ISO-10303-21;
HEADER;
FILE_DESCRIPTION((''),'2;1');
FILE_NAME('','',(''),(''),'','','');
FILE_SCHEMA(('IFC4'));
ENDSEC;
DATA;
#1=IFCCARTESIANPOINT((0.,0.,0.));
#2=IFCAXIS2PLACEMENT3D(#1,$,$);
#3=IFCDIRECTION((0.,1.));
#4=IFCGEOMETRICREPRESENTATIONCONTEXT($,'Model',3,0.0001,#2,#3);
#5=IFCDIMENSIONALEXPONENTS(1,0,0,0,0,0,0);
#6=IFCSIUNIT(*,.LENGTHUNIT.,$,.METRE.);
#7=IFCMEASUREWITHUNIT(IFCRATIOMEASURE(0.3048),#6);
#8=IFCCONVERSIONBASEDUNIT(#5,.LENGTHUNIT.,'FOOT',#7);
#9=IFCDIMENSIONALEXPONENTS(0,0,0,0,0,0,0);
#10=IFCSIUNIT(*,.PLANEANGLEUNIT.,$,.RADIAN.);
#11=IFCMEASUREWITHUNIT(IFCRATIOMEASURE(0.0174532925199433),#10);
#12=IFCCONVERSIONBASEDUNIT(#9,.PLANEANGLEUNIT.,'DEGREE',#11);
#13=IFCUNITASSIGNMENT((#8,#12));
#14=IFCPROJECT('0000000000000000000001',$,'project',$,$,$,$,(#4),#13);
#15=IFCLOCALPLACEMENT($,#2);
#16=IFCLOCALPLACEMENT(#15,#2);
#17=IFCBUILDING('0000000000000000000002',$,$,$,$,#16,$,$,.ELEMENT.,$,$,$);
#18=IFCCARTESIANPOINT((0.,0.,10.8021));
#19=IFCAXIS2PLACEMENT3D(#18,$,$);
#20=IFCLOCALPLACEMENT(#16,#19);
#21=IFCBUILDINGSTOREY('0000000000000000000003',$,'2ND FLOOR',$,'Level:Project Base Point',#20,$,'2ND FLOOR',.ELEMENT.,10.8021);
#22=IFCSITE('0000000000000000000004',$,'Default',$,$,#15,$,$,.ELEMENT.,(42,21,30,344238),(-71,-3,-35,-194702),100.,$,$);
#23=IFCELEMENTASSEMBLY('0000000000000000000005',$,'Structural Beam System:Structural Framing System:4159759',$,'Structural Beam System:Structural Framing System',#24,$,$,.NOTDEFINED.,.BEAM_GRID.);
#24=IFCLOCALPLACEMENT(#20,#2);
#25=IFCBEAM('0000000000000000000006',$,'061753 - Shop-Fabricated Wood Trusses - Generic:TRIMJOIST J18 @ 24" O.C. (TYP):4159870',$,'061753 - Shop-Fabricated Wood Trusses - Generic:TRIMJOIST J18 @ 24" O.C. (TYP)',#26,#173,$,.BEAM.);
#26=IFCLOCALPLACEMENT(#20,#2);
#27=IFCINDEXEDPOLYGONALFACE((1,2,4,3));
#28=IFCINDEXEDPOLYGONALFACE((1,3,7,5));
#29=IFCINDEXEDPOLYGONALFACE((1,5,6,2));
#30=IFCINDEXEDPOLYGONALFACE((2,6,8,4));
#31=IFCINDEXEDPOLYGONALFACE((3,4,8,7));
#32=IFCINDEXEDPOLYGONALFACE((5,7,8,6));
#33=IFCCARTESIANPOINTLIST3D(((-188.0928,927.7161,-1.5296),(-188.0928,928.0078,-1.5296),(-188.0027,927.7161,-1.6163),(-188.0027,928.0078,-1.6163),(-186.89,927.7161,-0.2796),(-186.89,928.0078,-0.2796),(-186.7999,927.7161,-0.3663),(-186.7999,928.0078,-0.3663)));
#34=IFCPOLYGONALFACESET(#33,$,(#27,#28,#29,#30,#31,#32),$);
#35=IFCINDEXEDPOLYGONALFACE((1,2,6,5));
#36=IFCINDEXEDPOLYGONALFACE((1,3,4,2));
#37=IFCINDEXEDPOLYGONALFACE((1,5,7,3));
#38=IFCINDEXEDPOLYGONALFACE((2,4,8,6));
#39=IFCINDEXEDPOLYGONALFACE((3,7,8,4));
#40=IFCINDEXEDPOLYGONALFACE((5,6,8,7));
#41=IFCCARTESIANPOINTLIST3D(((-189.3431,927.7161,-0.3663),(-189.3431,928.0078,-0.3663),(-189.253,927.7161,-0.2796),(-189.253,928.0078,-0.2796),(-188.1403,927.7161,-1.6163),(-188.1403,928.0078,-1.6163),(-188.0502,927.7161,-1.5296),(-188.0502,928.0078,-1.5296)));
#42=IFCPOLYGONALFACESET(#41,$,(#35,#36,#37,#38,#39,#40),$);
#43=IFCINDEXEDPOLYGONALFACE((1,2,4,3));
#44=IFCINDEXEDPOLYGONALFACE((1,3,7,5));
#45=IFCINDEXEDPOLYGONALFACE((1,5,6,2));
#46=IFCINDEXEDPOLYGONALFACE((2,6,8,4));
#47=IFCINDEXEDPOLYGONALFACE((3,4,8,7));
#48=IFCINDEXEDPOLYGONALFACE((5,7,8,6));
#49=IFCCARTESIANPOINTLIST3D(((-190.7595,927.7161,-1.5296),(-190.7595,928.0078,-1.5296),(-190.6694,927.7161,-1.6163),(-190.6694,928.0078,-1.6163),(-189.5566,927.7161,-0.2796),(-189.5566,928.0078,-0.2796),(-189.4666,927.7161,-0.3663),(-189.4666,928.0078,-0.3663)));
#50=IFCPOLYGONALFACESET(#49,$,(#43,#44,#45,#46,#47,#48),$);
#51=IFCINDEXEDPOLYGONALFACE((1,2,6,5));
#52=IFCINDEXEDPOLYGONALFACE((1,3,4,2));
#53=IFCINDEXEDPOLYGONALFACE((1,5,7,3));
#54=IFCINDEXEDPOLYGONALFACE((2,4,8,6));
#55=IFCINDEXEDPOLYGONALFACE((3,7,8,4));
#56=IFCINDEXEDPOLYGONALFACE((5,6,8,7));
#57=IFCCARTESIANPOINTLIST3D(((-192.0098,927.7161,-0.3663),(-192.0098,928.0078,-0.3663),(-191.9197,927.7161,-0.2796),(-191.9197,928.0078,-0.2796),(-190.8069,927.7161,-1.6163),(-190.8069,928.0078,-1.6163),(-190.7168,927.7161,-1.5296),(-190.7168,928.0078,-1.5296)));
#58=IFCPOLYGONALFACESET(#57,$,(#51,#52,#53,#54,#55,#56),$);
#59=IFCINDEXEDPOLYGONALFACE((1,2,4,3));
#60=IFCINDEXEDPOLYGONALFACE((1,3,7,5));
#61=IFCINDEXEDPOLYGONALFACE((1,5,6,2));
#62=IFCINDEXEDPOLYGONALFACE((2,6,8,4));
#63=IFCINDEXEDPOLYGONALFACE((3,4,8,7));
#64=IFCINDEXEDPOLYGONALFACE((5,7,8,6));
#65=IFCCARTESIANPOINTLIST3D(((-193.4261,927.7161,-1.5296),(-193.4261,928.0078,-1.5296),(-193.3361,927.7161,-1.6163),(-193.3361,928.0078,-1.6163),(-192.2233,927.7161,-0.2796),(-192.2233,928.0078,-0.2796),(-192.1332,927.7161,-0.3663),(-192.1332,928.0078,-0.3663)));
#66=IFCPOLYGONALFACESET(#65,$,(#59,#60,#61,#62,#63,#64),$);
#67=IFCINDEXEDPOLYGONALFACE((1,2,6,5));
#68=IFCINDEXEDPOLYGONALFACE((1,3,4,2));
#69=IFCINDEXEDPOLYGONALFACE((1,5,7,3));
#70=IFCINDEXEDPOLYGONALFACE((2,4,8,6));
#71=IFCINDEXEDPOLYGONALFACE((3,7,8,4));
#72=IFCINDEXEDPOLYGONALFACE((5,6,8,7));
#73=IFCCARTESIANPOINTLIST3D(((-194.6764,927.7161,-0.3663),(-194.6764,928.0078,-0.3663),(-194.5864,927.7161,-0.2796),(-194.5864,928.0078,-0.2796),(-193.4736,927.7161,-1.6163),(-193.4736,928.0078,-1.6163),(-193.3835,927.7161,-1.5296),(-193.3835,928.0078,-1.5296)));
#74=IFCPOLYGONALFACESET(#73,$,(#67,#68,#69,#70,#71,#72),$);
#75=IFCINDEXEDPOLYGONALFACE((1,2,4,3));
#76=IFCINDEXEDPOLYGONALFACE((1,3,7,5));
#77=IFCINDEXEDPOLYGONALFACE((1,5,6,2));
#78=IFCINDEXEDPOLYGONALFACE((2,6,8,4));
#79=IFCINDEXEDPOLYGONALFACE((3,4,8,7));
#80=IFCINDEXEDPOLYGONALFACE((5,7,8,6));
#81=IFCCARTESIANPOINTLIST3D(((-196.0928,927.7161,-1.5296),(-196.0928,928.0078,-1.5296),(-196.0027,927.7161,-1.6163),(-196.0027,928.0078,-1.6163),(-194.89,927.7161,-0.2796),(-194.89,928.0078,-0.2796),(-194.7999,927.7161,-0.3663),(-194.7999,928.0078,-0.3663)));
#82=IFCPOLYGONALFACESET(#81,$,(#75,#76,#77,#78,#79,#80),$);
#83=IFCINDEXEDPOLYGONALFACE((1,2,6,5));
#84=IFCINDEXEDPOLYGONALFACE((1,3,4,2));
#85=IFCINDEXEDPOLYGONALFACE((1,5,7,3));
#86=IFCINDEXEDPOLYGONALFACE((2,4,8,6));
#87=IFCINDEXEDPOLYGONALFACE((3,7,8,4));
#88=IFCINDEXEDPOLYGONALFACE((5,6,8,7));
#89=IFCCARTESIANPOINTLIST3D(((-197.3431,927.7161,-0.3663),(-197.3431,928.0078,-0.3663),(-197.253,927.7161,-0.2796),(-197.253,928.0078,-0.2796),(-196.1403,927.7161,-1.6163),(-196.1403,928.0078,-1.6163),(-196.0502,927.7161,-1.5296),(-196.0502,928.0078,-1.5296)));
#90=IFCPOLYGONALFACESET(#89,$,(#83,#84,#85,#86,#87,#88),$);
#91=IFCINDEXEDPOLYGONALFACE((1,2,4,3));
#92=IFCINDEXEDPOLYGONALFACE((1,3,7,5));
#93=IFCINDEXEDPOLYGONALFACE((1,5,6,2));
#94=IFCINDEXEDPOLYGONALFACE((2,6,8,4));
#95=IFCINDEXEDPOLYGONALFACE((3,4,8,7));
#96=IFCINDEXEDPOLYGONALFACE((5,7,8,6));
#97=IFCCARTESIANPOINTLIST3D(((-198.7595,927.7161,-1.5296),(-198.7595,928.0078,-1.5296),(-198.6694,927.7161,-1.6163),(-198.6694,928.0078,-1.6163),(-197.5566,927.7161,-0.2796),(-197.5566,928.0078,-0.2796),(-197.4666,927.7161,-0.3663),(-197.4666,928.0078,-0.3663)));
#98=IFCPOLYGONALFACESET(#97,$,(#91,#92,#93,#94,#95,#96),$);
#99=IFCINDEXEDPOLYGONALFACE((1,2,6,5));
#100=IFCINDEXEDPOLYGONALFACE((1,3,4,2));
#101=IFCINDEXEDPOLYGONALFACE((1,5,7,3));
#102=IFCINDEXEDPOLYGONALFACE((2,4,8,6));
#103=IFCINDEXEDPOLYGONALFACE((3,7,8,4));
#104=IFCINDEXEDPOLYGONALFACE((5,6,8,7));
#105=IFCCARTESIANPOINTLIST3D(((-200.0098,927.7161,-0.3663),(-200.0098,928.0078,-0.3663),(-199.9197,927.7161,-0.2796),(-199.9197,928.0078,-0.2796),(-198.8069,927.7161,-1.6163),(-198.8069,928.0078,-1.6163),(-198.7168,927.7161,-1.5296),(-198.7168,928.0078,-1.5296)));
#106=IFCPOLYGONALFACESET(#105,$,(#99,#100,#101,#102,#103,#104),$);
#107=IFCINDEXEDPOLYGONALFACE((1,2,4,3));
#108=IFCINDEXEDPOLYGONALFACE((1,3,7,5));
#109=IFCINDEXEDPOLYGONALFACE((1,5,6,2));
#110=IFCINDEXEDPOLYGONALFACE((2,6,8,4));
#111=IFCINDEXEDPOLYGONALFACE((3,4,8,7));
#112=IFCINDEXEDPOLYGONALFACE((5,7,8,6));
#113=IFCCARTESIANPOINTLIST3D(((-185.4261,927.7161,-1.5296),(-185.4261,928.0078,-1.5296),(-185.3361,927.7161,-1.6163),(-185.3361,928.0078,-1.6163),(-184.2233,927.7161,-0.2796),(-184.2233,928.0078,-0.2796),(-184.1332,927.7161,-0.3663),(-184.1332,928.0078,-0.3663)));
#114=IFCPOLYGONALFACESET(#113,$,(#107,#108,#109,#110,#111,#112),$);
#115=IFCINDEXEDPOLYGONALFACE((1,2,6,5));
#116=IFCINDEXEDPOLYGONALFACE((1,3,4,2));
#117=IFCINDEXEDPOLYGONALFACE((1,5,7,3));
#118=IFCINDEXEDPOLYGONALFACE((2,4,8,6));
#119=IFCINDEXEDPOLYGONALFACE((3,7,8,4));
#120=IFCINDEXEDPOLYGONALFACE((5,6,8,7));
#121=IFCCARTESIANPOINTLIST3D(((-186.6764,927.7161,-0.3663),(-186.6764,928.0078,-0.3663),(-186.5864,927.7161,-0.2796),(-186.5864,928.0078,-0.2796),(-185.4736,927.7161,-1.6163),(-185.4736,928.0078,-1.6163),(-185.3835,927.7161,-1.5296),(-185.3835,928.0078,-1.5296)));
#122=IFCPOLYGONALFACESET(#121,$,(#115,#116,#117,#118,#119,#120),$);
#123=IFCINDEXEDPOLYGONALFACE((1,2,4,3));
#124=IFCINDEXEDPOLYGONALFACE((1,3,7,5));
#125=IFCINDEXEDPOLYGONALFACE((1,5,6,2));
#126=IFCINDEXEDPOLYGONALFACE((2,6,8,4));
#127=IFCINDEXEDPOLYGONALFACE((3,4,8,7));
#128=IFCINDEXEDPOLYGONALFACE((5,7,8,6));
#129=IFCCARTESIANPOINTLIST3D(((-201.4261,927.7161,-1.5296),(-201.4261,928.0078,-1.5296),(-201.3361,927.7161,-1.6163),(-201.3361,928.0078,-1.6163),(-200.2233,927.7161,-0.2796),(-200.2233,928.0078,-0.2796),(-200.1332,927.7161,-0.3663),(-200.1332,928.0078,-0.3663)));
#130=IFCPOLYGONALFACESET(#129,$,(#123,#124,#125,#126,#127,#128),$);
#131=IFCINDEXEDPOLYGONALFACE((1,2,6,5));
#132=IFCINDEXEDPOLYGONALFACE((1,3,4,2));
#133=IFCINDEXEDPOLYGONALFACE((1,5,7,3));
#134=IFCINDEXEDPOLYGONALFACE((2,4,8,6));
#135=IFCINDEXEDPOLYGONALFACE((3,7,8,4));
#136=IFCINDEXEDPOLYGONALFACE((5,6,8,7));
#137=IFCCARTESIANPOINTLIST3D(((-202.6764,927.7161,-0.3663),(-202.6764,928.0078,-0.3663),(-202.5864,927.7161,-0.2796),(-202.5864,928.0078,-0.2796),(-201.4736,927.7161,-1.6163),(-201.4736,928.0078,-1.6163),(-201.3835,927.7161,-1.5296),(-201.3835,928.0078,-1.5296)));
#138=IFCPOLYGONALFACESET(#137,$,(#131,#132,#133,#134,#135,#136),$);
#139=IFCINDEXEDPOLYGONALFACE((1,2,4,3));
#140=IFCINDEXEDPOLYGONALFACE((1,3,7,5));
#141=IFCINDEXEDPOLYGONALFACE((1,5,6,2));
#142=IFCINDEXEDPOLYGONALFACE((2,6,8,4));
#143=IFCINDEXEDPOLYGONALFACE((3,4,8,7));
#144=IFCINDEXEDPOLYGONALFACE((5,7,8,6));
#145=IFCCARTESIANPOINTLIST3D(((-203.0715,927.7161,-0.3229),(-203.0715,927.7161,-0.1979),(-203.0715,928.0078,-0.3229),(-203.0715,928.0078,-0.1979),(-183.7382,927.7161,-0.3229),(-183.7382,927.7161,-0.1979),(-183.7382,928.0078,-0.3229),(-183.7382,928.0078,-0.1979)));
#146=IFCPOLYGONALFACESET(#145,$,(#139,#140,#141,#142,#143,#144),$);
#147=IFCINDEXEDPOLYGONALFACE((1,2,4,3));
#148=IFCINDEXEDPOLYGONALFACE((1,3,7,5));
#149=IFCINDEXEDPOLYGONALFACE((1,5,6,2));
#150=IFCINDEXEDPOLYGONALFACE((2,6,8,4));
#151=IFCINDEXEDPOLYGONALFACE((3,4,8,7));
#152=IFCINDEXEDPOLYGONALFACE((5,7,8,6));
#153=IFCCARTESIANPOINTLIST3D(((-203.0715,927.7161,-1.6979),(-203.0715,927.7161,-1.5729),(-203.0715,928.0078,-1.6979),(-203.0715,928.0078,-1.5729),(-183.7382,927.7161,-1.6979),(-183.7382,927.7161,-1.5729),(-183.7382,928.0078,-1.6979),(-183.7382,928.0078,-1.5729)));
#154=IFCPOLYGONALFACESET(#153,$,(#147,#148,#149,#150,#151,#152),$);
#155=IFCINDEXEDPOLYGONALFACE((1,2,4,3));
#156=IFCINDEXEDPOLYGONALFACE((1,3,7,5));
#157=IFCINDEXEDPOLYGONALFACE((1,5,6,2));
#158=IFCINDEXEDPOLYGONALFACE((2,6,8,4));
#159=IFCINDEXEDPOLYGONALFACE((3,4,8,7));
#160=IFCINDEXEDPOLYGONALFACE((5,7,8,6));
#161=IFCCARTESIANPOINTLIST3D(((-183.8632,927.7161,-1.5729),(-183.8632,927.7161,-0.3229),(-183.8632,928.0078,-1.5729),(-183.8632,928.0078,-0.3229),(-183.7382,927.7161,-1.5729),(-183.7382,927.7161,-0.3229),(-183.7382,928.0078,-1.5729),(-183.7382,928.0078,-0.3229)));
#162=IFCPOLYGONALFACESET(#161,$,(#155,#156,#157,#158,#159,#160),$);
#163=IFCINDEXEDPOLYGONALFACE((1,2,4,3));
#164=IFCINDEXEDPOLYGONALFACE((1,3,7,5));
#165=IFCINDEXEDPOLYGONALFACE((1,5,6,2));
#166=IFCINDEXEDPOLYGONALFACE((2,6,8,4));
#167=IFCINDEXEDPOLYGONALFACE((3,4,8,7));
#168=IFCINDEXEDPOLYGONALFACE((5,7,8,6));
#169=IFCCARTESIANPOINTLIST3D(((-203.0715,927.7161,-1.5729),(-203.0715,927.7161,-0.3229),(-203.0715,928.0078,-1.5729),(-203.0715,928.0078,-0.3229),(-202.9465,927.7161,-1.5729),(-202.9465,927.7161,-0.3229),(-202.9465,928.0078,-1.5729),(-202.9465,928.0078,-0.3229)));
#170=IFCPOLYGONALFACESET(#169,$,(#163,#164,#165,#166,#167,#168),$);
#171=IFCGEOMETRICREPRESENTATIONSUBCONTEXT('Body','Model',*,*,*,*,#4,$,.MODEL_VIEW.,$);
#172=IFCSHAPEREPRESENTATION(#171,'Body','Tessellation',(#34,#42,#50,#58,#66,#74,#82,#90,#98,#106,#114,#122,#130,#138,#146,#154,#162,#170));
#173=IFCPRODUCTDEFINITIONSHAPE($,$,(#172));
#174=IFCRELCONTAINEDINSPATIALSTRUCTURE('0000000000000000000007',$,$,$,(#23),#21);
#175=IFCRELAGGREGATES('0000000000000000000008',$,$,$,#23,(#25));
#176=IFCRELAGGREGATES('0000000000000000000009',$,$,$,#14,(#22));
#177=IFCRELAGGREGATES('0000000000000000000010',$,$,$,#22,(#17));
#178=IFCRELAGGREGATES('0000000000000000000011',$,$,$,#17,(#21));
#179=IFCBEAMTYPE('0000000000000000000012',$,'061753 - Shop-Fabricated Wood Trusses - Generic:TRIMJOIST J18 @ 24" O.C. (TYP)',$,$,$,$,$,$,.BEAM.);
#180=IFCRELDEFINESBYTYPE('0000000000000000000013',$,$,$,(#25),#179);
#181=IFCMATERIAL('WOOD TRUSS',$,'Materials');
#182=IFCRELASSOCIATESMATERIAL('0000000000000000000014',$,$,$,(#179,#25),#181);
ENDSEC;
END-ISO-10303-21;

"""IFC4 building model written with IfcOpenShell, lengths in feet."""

from ifc_helpers import new_model, entity, si_unit, converted_unit, direction, frame, frame_2d, origin, origin_2d_with_axis, place, context, subcontext, project, spatial, rectangle, extrude, source, transform, mapped, material, material_profile, profile_set, profile_usage, type_object, type_shapes, element, aggregate, save


model = new_model("IFC4")

# Units and contexts
model_context = context("Model", 3, precision=0.0001, world=origin(), true_north=direction((0.0, 1.0)))
body_context = subcontext(model_context, "Body", "Model", "MODEL_VIEW")
ifc_project = project(units=[converted_unit("LENGTHUNIT", "FOOT", entity("IfcRatioMeasure", 0.3048), si_unit("LENGTHUNIT", "METRE"), dimensions=[1, 0, 0, 0, 0, 0, 0]), converted_unit("PLANEANGLEUNIT", "DEGREE", entity("IfcRatioMeasure", 0.0174532925199433), si_unit("PLANEANGLEUNIT", "RADIAN"), dimensions=[0, 0, 0, 0, 0, 0, 0])], contexts=[model_context])

# Site, building, storey
site_placement = place(None, origin())
site = spatial("IfcSite", under=ifc_project, at=site_placement, Name="Default", CompositionType="ELEMENT", RefLatitude=(42, 21, 30, 344238), RefLongitude=(-71, -3, -35, -194702), RefElevation=100.0)
building_placement = place(site_placement, origin())
building = spatial("IfcBuilding", under=site, at=building_placement, CompositionType="ELEMENT")
storey_placement = place(building_placement, frame((0.0, 0.0, 10.8021)))
storey = spatial("IfcBuildingStorey", under=building, at=storey_placement, Name="2ND FLOOR", ObjectType="Level:Project Base Point", LongName="2ND FLOOR", CompositionType="ELEMENT", Elevation=10.8021)

# Element assembly, beam
ifc_material_1 = material(Name="WOOD TRUSS", Category="Materials")
ifc_material_profile_1 = material_profile(ifc_material_1, rectangle(XDim=1.7347, YDim=0.125, at=frame_2d((0.0, 0.0), x_axis=(1.0, 0.0))), Name="TRIMJOIST J18 @ 24\" O.C. (TYP)")
ifc_material_profile_2 = material_profile(ifc_material_1, rectangle(XDim=1.7347, YDim=0.125, at=frame_2d((0.0, 0.0), x_axis=(1.0, 0.0))), Name="TRIMJOIST J18 @ 24\" O.C. (TYP)")
ifc_material_profile_3 = material_profile(ifc_material_1, rectangle(XDim=1.7347, YDim=0.125, at=frame_2d((0.0, 0.0), x_axis=(1.0, 0.0))), Name="TRIMJOIST J18 @ 24\" O.C. (TYP)")
ifc_material_profile_4 = material_profile(ifc_material_1, rectangle(XDim=1.7347, YDim=0.125, at=frame_2d((0.0, 0.0), x_axis=(1.0, 0.0))), Name="TRIMJOIST J18 @ 24\" O.C. (TYP)")
ifc_material_profile_5 = material_profile(ifc_material_1, rectangle(XDim=1.7347, YDim=0.125, at=frame_2d((0.0, 0.0), x_axis=(1.0, 0.0))), Name="TRIMJOIST J18 @ 24\" O.C. (TYP)")
ifc_material_profile_6 = material_profile(ifc_material_1, rectangle(XDim=1.7347, YDim=0.125, at=frame_2d((0.0, 0.0), x_axis=(1.0, 0.0))), Name="TRIMJOIST J18 @ 24\" O.C. (TYP)")
ifc_material_profile_7 = material_profile(ifc_material_1, rectangle(XDim=1.7347, YDim=0.125, at=frame_2d((0.0, 0.0), x_axis=(1.0, 0.0))), Name="TRIMJOIST J18 @ 24\" O.C. (TYP)")
ifc_material_profile_8 = material_profile(ifc_material_1, rectangle(XDim=1.7347, YDim=0.125, at=frame_2d((0.0, 0.0), x_axis=(1.0, 0.0))), Name="TRIMJOIST J18 @ 24\" O.C. (TYP)")
ifc_material_profile_9 = material_profile(ifc_material_1, rectangle(XDim=1.7347, YDim=0.125, at=frame_2d((0.0, 0.0), x_axis=(1.0, 0.0))), Name="TRIMJOIST J18 @ 24\" O.C. (TYP)")
ifc_material_profile_10 = material_profile(ifc_material_1, rectangle(XDim=1.7347, YDim=0.125, at=origin_2d_with_axis()), Name="TRIMJOIST J18 @ 24\" O.C. (TYP)")
ifc_material_profile_11 = material_profile(ifc_material_1, rectangle(XDim=0.125, YDim=0.2917, at=origin_2d_with_axis()), Name="TRIMJOIST J18 @ 24\" O.C. (TYP)")
ifc_material_profile_12 = material_profile(ifc_material_1, rectangle(XDim=0.125, YDim=0.2917, at=origin_2d_with_axis()), Name="TRIMJOIST J18 @ 24\" O.C. (TYP)")
ifc_material_profile_13 = material_profile(ifc_material_1, rectangle(XDim=1.25, YDim=0.2917, at=origin_2d_with_axis()), Name="TRIMJOIST J18 @ 24\" O.C. (TYP)")
ifc_material_profile_14 = material_profile(ifc_material_1, rectangle(XDim=1.25, YDim=0.2917, at=origin_2d_with_axis()), Name="TRIMJOIST J18 @ 24\" O.C. (TYP)")
ifc_profile_set_1 = profile_set([ifc_material_profile_1, ifc_material_profile_2, ifc_material_profile_3, ifc_material_profile_4, ifc_material_profile_5, ifc_material_profile_6, ifc_material_profile_7, ifc_material_profile_8, ifc_material_profile_9, ifc_material_profile_10, ifc_material_profile_11, ifc_material_profile_12, ifc_material_profile_13, ifc_material_profile_14], Name="TRIMJOIST J18 @ 24\" O.C. (TYP)")
beam_type_1 = type_object("IfcBeamType", Name="061753 - Shop-Fabricated Wood Trusses - Generic:TRIMJOIST J18 @ 24\" O.C. (TYP)", PredefinedType="BEAM", material=ifc_profile_set_1)
shared_shape_1 = source(origin(), body_context, "Body", "SweptSolid", [
    extrude(rectangle(XDim=1.7347, YDim=0.125, at=frame_2d((0.0, 0.0), x_axis=(1.0, 0.0))), frame((5.9585, -0.1458, 0.0), z_axis=(0.0, 1.0, 0.0), x_axis=(0.693383, 0.0, 0.720569)), (0.0, 0.0, 1.0), 0.2917),
    extrude(rectangle(XDim=1.7347, YDim=0.125, at=origin_2d_with_axis()), frame((4.7082, -0.1458, 0.0), z_axis=(0.0, 1.0, 0.0), x_axis=(0.693383, 0.0, -0.720569)), (0.0, 0.0, 1.0), 0.2917),
    extrude(rectangle(XDim=1.7347, YDim=0.125, at=frame_2d((0.0, 0.0), x_axis=(1.0, 0.0))), frame((3.2918, -0.1458, 0.0), z_axis=(0.0, 1.0, 0.0), x_axis=(0.693383, 0.0, 0.720569)), (0.0, 0.0, 1.0), 0.2917),
    extrude(rectangle(XDim=1.7347, YDim=0.125, at=frame_2d((0.0, 0.0), x_axis=(1.0, 0.0))), frame((2.0415, -0.1458, 0.0), z_axis=(0.0, 1.0, 0.0), x_axis=(0.693383, 0.0, -0.720569)), (0.0, 0.0, 1.0), 0.2917),
    extrude(rectangle(XDim=1.7347, YDim=0.125, at=frame_2d((0.0, 0.0), x_axis=(1.0, 0.0))), frame((0.6251, -0.1458, 0.0), z_axis=(0.0, 1.0, 0.0), x_axis=(0.693383, 0.0, 0.720569)), (0.0, 0.0, 1.0), 0.2917),
    extrude(rectangle(XDim=1.7347, YDim=0.125, at=frame_2d((0.0, 0.0), x_axis=(1.0, 0.0))), frame((-0.6251, -0.1458, 0.0), z_axis=(0.0, 1.0, 0.0), x_axis=(0.693383, 0.0, -0.720569)), (0.0, 0.0, 1.0), 0.2917),
    extrude(rectangle(XDim=1.7347, YDim=0.125, at=frame_2d((0.0, 0.0), x_axis=(1.0, 0.0))), frame((-2.0415, -0.1458, 0.0), z_axis=(0.0, 1.0, 0.0), x_axis=(0.693383, 0.0, 0.720569)), (0.0, 0.0, 1.0), 0.2917),
    extrude(rectangle(XDim=1.7347, YDim=0.125, at=origin_2d_with_axis()), frame((-3.2918, -0.1458, 0.0), z_axis=(0.0, 1.0, 0.0), x_axis=(0.693383, 0.0, -0.720569)), (0.0, 0.0, 1.0), 0.2917),
    extrude(rectangle(XDim=1.7347, YDim=0.125, at=frame_2d((0.0, 0.0), x_axis=(1.0, 0.0))), frame((-4.7082, -0.1458, 0.0), z_axis=(0.0, 1.0, 0.0), x_axis=(0.693383, 0.0, 0.720569)), (0.0, 0.0, 1.0), 0.2917),
    extrude(rectangle(XDim=1.7347, YDim=0.125, at=frame_2d((0.0, 0.0), x_axis=(1.0, 0.0))), frame((-5.9585, -0.1458, 0.0), z_axis=(0.0, 1.0, 0.0), x_axis=(0.693383, 0.0, -0.720569)), (0.0, 0.0, 1.0), 0.2917),
    extrude(rectangle(XDim=1.7347, YDim=0.125, at=frame_2d((0.0, 0.0), x_axis=(1.0, 0.0))), frame((8.6251, -0.1458, 0.0), z_axis=(0.0, 1.0, 0.0), x_axis=(0.693383, 0.0, 0.720569)), (0.0, 0.0, 1.0), 0.2917),
    extrude(rectangle(XDim=1.7347, YDim=0.125, at=origin_2d_with_axis()), frame((7.3749, -0.1458, 0.0), z_axis=(0.0, 1.0, 0.0), x_axis=(0.693383, 0.0, -0.720569)), (0.0, 0.0, 1.0), 0.2917),
    extrude(rectangle(XDim=1.7347, YDim=0.125, at=frame_2d((0.0, 0.0), x_axis=(1.0, 0.0))), frame((-7.3749, -0.1458, 0.0), z_axis=(0.0, 1.0, 0.0), x_axis=(0.693383, 0.0, 0.720569)), (0.0, 0.0, 1.0), 0.2917),
    extrude(rectangle(XDim=1.7347, YDim=0.125, at=origin_2d_with_axis()), frame((-8.6251, -0.1458, 0.0), z_axis=(0.0, 1.0, 0.0), x_axis=(0.693383, 0.0, -0.720569)), (0.0, 0.0, 1.0), 0.2917),
    extrude(rectangle(XDim=0.125, YDim=0.2917, at=origin_2d_with_axis()), frame((-9.6667, 0.0, 0.6875), z_axis=(1.0, 0.0, 0.0), x_axis=(0.0, 0.0, -1.0)), (0.0, 0.0, 1.0), 19.3333),
    extrude(rectangle(XDim=0.125, YDim=0.2917, at=origin_2d_with_axis()), frame((-9.6667, 0.0, -0.6875), z_axis=(1.0, 0.0, 0.0), x_axis=(0.0, 0.0, -1.0)), (0.0, 0.0, 1.0), 19.3333),
    extrude(rectangle(XDim=1.25, YDim=0.2917, at=origin_2d_with_axis()), frame((9.5417, 0.0, 0.0), z_axis=(1.0, 0.0, 0.0), x_axis=(0.0, 0.0, -1.0)), (0.0, 0.0, 1.0), 0.125),
    extrude(rectangle(XDim=1.25, YDim=0.2917, at=origin_2d_with_axis()), frame((-9.6667, 0.0, 0.0), z_axis=(1.0, 0.0, 0.0), x_axis=(0.0, 0.0, -1.0)), (0.0, 0.0, 1.0), 0.125),
])
type_shapes(beam_type_1, [shared_shape_1])
assembly_1_placement = place(storey_placement, origin())
assembly_1 = element("IfcElementAssembly", 1, at=assembly_1_placement, inside=storey, Name="Structural Beam System:Structural Framing System:4159759", ObjectType="Structural Beam System:Structural Framing System", AssemblyPlace="NOTDEFINED", PredefinedType="BEAM_GRID")
ifc_profile_usage_1 = profile_usage(ifc_profile_set_1, cardinal=8)
beam_1_placement = place(assembly_1_placement, frame((-193.4048, 927.8619, -0.9479)))
beam_1 = element("IfcBeam", 2, at=beam_1_placement, type_object=beam_type_1, material=ifc_profile_usage_1, Name="061753 - Shop-Fabricated Wood Trusses - Generic:TRIMJOIST J18 @ 24\" O.C. (TYP):4159870", ObjectType="061753 - Shop-Fabricated Wood Trusses - Generic:TRIMJOIST J18 @ 24\" O.C. (TYP)", PredefinedType="BEAM", context=body_context, shape_type="MappedRepresentation", body=[
    mapped(shared_shape_1, transform((0.0, 0.0, 0.0), scale=1.0)),
])
aggregate(assembly_1, [beam_1])

save(model, "model.ifc")
